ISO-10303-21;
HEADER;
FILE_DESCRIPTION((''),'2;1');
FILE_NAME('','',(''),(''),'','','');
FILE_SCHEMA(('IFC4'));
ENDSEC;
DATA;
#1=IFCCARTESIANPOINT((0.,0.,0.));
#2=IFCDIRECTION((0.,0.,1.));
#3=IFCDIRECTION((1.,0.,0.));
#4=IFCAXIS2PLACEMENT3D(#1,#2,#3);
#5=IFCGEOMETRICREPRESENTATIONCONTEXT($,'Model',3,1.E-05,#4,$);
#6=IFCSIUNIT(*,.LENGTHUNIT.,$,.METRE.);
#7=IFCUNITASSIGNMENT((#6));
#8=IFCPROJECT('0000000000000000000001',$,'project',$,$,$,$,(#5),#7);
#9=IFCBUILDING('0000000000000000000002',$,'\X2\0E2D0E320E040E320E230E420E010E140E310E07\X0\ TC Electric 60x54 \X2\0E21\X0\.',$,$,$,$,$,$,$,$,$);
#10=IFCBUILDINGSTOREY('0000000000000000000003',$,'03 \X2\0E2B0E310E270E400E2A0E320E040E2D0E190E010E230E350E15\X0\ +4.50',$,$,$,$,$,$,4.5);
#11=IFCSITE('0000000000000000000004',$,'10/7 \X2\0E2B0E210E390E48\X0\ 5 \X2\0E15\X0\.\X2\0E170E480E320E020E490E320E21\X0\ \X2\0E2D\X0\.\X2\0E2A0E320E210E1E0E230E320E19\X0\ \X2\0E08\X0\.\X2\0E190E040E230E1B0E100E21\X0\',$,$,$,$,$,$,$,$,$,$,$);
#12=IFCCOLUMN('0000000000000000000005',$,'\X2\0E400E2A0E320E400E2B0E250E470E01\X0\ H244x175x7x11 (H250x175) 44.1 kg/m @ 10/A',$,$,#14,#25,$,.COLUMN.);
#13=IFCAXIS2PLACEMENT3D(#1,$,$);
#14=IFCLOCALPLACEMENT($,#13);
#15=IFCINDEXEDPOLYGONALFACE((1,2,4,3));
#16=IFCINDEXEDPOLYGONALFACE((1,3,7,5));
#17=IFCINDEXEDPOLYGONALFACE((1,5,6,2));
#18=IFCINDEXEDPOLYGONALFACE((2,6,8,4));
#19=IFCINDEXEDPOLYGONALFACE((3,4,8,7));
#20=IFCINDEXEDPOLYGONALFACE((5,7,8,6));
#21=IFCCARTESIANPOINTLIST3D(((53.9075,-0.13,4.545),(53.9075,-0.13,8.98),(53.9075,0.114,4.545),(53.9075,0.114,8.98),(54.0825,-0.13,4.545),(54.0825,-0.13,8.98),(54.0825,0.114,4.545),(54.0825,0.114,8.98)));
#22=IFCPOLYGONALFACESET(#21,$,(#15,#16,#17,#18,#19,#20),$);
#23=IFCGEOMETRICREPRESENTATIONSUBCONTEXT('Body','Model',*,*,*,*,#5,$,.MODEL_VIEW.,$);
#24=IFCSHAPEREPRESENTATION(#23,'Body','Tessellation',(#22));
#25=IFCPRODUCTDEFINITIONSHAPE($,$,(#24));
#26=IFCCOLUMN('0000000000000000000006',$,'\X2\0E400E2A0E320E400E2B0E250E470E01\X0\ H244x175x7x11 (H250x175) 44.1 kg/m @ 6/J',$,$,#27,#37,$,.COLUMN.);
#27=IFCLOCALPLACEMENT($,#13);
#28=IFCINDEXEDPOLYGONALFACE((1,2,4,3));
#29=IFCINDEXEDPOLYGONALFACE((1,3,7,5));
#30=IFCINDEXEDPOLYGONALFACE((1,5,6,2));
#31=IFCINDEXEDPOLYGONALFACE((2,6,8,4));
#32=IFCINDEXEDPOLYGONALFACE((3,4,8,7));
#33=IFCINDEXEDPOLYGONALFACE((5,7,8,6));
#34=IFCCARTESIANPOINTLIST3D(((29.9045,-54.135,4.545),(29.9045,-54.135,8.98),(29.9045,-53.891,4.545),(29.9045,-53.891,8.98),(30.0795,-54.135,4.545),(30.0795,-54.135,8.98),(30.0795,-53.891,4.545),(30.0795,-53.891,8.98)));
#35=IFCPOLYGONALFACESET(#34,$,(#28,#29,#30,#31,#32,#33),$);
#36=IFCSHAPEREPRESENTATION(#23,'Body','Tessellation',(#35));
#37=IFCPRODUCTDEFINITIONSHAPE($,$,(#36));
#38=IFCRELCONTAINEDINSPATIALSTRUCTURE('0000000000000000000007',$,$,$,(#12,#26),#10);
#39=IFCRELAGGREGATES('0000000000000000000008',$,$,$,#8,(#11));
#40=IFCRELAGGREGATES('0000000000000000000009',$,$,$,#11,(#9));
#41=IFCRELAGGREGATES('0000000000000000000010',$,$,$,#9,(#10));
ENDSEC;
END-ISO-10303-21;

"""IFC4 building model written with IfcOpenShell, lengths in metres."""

from ifc_helpers import new_model, si_unit, frame, origin, origin_with_axes, origin_2d, place, context, subcontext, project, spatial, rectangle, extrude, element, save


model = new_model("IFC4")

# Units and contexts
model_context = context("Model", 3, precision=1e-05, world=origin_with_axes())
body_context = subcontext(model_context, "Body", "Model", "MODEL_VIEW")
ifc_project = project(units=[si_unit("LENGTHUNIT", "METRE")], contexts=[model_context])

# Site, building, storey
site = spatial("IfcSite", under=ifc_project, Name="10/7 หมู่ 5 ต.ท่าข้าม อ.สามพราน จ.นครปฐม")
building = spatial("IfcBuilding", under=site, Name="อาคารโกดัง TC Electric 60x54 ม.")
storey = spatial("IfcBuildingStorey", under=building, Name="03 หัวเสาคอนกรีต +4.50", Elevation=4.5)

# Columns
for number, where, z_axis, x_axis, name in (
    (1, (53.995, -0.008, 4.545), (0.0, 0.0, 1.0), (1.0, 0.0, 0.0), "เสาเหล็ก H244x175x7x11 (H250x175) 44.1 kg/m @ 10/A"),
    (2, (29.992, -54.013, 4.545), (0.0, 0.0, 1.0), (1.0, 0.0, 0.0), "เสาเหล็ก H244x175x7x11 (H250x175) 44.1 kg/m @ 6/J"),
):
    element("IfcColumn", number, at=place(None, frame(where, z_axis=z_axis, x_axis=x_axis)), inside=storey, Name=name, PredefinedType="COLUMN", context=body_context, shape_type="SweptSolid", body=[
        extrude(rectangle(XDim=0.175, YDim=0.244, at=origin_2d()), origin(), (0.0, 0.0, 1.0), 4.435),
    ])

save(model, "model.ifc")
